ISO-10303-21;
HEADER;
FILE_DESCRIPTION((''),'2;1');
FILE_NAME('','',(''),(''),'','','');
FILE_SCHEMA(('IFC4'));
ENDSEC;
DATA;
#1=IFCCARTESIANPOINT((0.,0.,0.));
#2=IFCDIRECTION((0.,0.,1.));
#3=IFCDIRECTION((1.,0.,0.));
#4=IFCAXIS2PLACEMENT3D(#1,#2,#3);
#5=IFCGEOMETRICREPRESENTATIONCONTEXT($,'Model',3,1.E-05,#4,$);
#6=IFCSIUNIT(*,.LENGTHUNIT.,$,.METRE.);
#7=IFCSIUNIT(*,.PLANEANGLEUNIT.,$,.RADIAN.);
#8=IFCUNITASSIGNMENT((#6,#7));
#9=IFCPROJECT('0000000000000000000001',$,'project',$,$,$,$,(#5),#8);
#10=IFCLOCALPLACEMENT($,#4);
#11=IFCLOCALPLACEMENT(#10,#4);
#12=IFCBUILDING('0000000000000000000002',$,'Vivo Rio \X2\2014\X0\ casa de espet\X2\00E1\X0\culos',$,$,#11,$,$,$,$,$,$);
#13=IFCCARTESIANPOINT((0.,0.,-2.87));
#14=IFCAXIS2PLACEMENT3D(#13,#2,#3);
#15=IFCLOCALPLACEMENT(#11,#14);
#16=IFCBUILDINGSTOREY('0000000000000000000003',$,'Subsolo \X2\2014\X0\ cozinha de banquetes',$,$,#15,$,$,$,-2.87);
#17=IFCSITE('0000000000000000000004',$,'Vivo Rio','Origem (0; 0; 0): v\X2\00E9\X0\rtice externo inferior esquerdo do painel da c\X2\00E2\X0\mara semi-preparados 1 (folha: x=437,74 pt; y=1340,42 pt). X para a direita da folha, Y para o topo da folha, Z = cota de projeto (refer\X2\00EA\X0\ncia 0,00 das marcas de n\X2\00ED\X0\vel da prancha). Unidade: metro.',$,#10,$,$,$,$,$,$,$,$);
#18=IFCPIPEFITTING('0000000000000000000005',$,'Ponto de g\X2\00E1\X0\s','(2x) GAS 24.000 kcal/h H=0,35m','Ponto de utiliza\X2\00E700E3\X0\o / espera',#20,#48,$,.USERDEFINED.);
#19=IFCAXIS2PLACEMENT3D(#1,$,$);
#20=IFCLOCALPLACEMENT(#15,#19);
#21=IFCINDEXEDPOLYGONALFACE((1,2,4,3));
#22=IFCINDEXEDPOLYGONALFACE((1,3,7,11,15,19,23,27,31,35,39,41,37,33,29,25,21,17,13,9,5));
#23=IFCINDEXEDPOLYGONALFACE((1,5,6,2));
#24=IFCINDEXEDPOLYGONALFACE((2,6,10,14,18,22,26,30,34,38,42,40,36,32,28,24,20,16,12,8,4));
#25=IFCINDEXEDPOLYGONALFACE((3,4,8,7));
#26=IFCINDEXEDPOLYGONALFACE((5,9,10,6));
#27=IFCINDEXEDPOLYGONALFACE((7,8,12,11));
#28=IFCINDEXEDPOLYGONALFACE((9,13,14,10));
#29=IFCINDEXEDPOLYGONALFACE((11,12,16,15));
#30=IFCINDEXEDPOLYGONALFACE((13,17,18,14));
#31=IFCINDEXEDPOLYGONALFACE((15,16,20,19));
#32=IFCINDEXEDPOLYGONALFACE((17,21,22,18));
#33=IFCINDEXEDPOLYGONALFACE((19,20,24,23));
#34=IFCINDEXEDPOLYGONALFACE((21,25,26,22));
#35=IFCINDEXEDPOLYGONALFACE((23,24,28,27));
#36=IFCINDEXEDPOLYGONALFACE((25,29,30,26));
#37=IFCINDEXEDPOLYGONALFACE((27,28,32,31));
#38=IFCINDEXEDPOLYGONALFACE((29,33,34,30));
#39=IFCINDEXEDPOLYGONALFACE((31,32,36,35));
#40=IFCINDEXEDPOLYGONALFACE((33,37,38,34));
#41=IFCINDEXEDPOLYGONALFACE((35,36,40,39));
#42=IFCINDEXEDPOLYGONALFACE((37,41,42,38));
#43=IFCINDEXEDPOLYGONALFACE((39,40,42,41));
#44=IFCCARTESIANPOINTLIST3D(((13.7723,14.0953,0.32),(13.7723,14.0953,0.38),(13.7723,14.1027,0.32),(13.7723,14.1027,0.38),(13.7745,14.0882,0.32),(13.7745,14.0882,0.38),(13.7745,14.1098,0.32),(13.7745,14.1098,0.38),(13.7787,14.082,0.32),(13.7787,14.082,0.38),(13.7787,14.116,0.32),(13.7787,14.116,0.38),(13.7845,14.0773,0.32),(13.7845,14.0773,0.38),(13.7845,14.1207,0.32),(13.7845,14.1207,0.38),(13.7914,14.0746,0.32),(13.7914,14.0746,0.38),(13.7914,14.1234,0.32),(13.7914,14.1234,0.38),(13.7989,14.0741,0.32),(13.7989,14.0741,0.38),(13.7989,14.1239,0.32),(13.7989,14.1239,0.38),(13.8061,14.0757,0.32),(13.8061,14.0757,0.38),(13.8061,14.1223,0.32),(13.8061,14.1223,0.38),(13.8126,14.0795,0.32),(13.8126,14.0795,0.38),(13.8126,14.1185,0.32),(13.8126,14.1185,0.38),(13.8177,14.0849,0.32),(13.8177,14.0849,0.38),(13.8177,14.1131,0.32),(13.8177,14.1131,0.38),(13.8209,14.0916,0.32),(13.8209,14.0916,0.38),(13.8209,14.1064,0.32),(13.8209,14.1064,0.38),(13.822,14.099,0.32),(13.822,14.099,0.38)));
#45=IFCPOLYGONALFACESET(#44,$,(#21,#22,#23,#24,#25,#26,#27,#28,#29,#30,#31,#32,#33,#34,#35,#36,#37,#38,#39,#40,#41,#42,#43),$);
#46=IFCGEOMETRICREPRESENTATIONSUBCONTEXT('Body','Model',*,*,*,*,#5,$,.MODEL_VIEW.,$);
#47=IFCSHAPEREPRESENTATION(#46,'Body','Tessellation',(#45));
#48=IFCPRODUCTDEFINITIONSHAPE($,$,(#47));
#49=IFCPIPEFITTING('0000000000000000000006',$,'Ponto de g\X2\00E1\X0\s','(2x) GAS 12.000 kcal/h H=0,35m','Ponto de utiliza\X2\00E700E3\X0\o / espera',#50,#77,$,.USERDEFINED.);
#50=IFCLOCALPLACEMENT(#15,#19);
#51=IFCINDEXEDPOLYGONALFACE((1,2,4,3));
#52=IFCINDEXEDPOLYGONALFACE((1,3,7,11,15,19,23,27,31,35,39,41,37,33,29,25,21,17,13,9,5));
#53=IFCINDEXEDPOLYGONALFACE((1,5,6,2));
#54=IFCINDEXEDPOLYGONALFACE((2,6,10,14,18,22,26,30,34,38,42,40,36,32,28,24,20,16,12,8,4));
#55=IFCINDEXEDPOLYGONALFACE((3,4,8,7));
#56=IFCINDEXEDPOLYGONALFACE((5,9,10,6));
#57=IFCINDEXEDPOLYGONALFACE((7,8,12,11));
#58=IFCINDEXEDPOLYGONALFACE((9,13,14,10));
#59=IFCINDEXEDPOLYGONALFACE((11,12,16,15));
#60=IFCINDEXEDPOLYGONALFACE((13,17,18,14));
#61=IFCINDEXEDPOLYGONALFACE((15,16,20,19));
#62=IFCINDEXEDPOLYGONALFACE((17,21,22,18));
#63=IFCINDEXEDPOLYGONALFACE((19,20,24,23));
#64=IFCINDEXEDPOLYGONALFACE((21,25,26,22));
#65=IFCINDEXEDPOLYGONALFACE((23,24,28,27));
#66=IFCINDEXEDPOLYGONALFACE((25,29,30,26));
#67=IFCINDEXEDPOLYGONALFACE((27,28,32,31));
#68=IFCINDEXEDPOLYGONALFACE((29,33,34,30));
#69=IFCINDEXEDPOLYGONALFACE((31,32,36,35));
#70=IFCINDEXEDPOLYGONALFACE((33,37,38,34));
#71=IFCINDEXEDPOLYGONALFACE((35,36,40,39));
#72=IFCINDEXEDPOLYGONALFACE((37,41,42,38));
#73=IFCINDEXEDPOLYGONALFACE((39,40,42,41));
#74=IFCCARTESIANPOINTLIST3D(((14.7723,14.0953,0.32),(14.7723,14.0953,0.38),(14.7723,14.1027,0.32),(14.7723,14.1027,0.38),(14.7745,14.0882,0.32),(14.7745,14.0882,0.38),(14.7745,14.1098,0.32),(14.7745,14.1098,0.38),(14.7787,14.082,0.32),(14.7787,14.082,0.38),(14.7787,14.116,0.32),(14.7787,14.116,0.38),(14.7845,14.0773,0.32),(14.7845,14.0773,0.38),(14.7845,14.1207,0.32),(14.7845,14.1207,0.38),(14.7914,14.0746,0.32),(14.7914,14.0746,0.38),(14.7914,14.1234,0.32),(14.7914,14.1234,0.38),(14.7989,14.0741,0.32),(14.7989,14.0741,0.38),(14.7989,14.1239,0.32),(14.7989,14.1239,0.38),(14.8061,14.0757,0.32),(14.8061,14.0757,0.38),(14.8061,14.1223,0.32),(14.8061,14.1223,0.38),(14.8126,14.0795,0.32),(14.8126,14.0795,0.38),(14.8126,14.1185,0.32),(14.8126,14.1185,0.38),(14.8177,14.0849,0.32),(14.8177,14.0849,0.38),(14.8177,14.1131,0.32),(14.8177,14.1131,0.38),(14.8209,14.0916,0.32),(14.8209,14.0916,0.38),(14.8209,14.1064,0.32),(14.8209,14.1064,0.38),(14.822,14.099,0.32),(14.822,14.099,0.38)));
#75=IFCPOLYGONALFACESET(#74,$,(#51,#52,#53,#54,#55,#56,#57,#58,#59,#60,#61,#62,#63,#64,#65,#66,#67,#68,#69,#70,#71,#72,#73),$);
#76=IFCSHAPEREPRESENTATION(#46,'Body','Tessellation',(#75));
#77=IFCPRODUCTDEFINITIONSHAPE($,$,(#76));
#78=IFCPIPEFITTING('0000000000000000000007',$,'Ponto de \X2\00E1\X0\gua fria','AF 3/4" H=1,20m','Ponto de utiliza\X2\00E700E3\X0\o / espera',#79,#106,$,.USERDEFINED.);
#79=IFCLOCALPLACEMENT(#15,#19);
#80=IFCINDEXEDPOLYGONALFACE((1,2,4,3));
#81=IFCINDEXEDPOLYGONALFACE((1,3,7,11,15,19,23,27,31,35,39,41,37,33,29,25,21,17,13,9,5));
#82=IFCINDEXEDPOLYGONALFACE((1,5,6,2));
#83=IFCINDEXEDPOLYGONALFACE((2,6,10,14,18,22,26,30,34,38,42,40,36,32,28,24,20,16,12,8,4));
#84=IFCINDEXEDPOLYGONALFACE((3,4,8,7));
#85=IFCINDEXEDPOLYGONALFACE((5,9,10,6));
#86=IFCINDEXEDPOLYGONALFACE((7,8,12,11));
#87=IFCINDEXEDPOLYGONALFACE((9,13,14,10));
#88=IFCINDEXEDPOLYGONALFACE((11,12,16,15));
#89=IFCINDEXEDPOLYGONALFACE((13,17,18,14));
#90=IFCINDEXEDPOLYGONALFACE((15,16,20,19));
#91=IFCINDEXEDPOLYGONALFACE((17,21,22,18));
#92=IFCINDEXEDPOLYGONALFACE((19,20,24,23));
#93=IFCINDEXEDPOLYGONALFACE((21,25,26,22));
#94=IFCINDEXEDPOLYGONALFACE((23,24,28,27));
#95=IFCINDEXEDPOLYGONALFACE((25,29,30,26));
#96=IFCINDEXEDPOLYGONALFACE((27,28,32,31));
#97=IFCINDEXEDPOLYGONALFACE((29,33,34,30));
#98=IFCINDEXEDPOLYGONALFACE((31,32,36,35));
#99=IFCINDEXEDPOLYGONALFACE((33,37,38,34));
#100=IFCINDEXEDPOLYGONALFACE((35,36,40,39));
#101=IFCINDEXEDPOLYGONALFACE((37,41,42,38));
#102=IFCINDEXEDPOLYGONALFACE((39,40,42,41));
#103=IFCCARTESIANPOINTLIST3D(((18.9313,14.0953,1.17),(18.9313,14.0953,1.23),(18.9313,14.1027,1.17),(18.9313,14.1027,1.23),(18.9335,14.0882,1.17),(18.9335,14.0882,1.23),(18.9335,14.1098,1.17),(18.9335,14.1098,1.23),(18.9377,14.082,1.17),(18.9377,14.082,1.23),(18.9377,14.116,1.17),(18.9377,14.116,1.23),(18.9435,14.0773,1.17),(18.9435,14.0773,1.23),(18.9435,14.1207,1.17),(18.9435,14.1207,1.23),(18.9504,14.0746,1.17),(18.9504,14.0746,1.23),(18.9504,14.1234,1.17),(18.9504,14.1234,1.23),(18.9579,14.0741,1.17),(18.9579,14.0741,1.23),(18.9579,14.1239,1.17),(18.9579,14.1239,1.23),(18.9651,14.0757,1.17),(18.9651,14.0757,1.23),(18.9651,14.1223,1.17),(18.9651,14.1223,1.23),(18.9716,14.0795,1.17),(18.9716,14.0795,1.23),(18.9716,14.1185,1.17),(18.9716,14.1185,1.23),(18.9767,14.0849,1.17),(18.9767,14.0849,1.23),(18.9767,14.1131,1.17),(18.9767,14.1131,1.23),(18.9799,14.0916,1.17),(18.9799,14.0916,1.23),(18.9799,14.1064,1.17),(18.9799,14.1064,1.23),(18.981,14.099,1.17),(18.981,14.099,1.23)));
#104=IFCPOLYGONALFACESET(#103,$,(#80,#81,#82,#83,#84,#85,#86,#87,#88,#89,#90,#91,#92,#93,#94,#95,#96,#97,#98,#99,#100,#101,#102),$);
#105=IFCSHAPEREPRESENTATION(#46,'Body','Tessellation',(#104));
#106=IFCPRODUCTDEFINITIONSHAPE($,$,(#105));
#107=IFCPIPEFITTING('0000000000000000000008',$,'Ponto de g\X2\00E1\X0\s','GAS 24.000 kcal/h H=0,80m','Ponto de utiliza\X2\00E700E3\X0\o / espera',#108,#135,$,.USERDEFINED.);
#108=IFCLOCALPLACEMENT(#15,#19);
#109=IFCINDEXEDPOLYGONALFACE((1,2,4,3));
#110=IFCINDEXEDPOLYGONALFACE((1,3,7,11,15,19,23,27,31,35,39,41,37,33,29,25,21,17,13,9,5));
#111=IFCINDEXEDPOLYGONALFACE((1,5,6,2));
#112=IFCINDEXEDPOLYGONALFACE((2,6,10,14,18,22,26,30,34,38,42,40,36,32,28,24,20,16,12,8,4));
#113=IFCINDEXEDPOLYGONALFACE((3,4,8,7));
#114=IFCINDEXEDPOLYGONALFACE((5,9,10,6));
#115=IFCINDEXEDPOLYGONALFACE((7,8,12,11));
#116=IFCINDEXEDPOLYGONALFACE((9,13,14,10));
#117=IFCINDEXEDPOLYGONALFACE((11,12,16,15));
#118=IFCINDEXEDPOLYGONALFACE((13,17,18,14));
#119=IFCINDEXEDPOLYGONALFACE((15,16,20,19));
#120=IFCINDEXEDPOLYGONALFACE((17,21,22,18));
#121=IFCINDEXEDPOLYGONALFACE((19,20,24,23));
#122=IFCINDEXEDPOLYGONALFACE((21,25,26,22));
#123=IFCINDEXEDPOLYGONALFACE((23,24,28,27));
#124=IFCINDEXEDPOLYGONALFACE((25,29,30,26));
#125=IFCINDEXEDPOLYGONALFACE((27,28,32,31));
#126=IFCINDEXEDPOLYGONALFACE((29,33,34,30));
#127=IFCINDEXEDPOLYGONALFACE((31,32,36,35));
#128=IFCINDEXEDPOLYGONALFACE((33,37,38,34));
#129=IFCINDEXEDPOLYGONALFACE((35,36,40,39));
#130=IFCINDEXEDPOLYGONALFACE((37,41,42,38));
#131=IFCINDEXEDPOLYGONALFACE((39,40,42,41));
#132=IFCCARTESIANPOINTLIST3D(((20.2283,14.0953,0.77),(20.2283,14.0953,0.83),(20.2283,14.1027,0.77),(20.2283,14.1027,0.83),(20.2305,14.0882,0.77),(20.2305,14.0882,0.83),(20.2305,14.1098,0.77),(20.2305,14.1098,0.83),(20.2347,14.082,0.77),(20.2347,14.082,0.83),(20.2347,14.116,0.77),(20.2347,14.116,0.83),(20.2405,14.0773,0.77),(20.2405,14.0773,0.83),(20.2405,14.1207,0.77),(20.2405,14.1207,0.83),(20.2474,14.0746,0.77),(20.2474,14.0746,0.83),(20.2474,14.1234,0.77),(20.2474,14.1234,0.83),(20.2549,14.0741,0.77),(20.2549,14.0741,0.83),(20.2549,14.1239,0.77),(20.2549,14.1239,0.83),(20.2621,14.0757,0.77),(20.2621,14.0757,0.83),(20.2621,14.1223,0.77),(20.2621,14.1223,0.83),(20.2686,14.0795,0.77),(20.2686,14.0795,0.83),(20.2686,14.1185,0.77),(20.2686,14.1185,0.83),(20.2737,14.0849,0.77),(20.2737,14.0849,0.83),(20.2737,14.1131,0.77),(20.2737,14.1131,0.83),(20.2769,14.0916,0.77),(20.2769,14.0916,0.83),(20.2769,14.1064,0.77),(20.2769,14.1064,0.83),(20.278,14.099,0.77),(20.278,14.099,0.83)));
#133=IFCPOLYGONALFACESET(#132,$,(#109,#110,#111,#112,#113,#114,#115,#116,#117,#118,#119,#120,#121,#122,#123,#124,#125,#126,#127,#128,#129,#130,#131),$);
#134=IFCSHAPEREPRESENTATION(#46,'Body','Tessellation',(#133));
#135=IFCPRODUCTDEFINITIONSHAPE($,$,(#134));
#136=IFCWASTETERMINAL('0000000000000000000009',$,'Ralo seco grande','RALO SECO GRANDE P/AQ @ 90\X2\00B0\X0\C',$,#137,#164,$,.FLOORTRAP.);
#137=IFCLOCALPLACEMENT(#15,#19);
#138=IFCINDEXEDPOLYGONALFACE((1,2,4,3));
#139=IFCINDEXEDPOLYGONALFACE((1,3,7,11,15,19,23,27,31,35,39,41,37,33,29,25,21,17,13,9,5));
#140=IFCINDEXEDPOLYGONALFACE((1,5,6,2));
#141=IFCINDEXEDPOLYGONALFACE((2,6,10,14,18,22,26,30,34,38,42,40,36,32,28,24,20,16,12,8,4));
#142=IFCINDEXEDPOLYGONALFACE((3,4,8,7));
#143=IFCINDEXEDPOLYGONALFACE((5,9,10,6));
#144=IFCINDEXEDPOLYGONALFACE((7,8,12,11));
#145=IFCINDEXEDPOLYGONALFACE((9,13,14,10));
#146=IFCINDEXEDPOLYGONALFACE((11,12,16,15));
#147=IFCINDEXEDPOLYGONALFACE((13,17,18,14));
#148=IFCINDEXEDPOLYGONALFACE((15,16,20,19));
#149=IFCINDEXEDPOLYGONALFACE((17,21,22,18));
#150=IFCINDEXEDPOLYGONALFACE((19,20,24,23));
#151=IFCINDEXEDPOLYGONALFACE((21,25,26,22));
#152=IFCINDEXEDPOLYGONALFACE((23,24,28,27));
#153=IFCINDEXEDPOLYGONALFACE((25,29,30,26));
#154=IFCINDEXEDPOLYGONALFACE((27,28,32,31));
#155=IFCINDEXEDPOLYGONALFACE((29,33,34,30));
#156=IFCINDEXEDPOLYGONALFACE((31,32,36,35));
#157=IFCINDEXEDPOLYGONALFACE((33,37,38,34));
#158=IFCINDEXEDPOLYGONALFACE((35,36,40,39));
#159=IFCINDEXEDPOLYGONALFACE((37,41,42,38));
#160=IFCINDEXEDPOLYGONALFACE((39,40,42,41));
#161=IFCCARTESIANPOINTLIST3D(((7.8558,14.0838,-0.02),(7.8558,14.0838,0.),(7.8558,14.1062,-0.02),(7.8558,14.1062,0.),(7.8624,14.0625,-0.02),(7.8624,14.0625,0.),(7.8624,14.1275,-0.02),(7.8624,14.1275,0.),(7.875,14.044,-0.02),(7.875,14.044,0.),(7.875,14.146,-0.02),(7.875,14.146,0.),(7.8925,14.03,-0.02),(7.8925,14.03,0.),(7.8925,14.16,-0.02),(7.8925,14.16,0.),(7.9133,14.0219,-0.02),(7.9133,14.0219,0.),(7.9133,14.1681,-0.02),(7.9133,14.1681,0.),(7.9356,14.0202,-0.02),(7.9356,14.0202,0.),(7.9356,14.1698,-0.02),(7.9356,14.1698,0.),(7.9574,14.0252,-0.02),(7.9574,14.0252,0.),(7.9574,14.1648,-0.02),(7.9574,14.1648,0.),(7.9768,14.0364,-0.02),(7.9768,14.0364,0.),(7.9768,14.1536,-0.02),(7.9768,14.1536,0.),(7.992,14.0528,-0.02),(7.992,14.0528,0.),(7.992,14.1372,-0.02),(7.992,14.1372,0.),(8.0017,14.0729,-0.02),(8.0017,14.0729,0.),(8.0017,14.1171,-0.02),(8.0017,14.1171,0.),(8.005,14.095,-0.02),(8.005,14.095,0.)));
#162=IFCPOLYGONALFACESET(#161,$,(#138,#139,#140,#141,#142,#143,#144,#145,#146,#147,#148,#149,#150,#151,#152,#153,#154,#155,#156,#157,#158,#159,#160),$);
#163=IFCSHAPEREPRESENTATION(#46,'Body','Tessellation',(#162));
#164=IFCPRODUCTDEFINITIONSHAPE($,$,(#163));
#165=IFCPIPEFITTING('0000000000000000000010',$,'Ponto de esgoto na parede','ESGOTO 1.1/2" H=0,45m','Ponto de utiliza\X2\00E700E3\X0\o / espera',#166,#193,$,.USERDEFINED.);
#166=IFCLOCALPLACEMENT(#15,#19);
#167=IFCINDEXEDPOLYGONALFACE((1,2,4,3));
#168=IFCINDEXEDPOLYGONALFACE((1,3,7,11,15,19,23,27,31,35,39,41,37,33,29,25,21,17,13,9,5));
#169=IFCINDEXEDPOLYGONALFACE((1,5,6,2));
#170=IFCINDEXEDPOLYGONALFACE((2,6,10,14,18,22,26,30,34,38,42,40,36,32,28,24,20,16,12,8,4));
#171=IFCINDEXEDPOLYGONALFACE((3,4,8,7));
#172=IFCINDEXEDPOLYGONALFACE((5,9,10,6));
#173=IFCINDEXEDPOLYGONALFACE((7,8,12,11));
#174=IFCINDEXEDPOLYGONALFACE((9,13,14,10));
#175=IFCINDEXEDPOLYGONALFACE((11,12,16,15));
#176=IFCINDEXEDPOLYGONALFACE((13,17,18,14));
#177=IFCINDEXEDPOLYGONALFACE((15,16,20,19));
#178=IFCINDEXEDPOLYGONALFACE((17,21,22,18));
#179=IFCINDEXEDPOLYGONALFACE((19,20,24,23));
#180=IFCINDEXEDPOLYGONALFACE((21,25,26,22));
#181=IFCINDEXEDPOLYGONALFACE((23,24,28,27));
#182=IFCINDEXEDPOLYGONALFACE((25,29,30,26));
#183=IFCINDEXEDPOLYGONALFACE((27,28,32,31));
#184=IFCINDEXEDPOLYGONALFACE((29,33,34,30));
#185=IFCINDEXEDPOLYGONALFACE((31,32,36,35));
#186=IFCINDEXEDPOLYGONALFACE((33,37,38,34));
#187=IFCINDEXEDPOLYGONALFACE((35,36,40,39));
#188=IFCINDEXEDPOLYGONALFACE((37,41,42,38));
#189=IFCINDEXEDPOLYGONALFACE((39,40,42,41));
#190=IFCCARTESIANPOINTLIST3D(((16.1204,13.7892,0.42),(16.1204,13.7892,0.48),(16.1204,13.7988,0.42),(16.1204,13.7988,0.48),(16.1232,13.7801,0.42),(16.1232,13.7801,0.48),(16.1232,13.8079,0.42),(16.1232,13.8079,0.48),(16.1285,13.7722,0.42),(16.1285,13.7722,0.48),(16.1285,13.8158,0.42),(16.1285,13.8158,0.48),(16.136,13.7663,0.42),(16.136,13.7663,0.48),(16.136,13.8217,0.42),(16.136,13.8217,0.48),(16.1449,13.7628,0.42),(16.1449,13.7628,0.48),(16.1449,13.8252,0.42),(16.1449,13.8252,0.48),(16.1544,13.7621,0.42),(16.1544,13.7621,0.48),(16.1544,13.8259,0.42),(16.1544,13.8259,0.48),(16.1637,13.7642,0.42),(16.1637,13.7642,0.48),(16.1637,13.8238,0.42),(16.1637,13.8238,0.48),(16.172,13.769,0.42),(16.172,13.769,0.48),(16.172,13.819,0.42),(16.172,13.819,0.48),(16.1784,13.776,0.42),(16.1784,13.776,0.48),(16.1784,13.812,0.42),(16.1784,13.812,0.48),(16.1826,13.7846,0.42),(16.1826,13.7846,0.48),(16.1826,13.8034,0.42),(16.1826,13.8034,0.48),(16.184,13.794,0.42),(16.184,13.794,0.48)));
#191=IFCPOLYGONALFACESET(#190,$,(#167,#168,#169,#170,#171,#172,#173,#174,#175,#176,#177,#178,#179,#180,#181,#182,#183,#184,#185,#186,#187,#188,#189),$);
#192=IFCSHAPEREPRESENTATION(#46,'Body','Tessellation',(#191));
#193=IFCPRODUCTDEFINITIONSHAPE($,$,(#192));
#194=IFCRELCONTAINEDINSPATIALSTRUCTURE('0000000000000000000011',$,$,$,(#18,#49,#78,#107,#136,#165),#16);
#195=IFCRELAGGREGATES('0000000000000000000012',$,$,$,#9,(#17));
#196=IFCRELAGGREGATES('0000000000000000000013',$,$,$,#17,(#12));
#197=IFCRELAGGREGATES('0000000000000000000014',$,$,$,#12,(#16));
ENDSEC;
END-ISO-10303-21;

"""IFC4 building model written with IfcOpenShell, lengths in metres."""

from ifc_helpers import new_model, si_unit, frame, origin_with_axes, origin_2d, place, context, subcontext, project, spatial, circle, extrude, element, save


model = new_model("IFC4")

# Units and contexts
model_context = context("Model", 3, precision=1e-05, world=origin_with_axes())
body_context = subcontext(model_context, "Body", "Model", "MODEL_VIEW")
ifc_project = project(units=[si_unit("LENGTHUNIT", "METRE"), si_unit("PLANEANGLEUNIT", "RADIAN")], contexts=[model_context])

# Site, building, storey
site_placement = place(None, origin_with_axes())
site = spatial("IfcSite", under=ifc_project, at=site_placement, Name="Vivo Rio", Description="Origem (0; 0; 0): vértice externo inferior esquerdo do painel da câmara semi-preparados 1 (folha: x=437,74 pt; y=1340,42 pt). X para a direita da folha, Y para o topo da folha, Z = cota de projeto (referência 0,00 das marcas de nível da prancha). Unidade: metro.")
building_placement = place(site_placement, origin_with_axes())
building = spatial("IfcBuilding", under=site, at=building_placement, Name="Vivo Rio — casa de espetáculos")
storey_placement = place(building_placement, frame((0.0, 0.0, -2.87), z_axis=(0.0, 0.0, 1.0), x_axis=(1.0, 0.0, 0.0)))
storey = spatial("IfcBuildingStorey", under=building, at=storey_placement, Name="Subsolo — cozinha de banquetes", Elevation=-2.87)

# Pipe fittings
pipe_fitting_1_placement = place(storey_placement, origin_with_axes())
element("IfcPipeFitting", 1, at=pipe_fitting_1_placement, inside=storey, Name="Ponto de gás", Description="(2x) GAS 24.000 kcal/h H=0,35m", ObjectType="Ponto de utilização / espera", PredefinedType="USERDEFINED", context=body_context, shape_type="SweptSolid", body=[
    extrude(circle(Radius=0.025, at=origin_2d()), frame((13.797, 14.099, 0.32), z_axis=(0.0, 0.0, 1.0), x_axis=(1.0, 0.0, 0.0)), (0.0, 0.0, 1.0), 0.06),
])
pipe_fitting_2_placement = place(storey_placement, origin_with_axes())
element("IfcPipeFitting", 2, at=pipe_fitting_2_placement, inside=storey, Name="Ponto de gás", Description="(2x) GAS 12.000 kcal/h H=0,35m", ObjectType="Ponto de utilização / espera", PredefinedType="USERDEFINED", context=body_context, shape_type="SweptSolid", body=[
    extrude(circle(Radius=0.025, at=origin_2d()), frame((14.797, 14.099, 0.32), z_axis=(0.0, 0.0, 1.0), x_axis=(1.0, 0.0, 0.0)), (0.0, 0.0, 1.0), 0.06),
])
pipe_fitting_3_placement = place(storey_placement, origin_with_axes())
element("IfcPipeFitting", 3, at=pipe_fitting_3_placement, inside=storey, Name="Ponto de água fria", Description="AF 3/4\" H=1,20m", ObjectType="Ponto de utilização / espera", PredefinedType="USERDEFINED", context=body_context, shape_type="SweptSolid", body=[
    extrude(circle(Radius=0.025, at=origin_2d()), frame((18.956, 14.099, 1.17), z_axis=(0.0, 0.0, 1.0), x_axis=(1.0, 0.0, 0.0)), (0.0, 0.0, 1.0), 0.06),
])
pipe_fitting_4_placement = place(storey_placement, origin_with_axes())
element("IfcPipeFitting", 4, at=pipe_fitting_4_placement, inside=storey, Name="Ponto de gás", Description="GAS 24.000 kcal/h H=0,80m", ObjectType="Ponto de utilização / espera", PredefinedType="USERDEFINED", context=body_context, shape_type="SweptSolid", body=[
    extrude(circle(Radius=0.025, at=origin_2d()), frame((20.253, 14.099, 0.77), z_axis=(0.0, 0.0, 1.0), x_axis=(1.0, 0.0, 0.0)), (0.0, 0.0, 1.0), 0.06),
])

# Waste terminal
waste_terminal_1_placement = place(storey_placement, origin_with_axes())
element("IfcWasteTerminal", 5, at=waste_terminal_1_placement, inside=storey, Name="Ralo seco grande", Description="RALO SECO GRANDE P/AQ @ 90°C", PredefinedType="FLOORTRAP", context=body_context, shape_type="SweptSolid", body=[
    extrude(circle(Radius=0.075, at=origin_2d()), frame((7.93, 14.095, -0.02), z_axis=(0.0, 0.0, 1.0), x_axis=(1.0, 0.0, 0.0)), (0.0, 0.0, 1.0), 0.02),
])

# Pipe fitting
pipe_fitting_5_placement = place(storey_placement, origin_with_axes())
element("IfcPipeFitting", 6, at=pipe_fitting_5_placement, inside=storey, Name="Ponto de esgoto na parede", Description="ESGOTO 1.1/2\" H=0,45m", ObjectType="Ponto de utilização / espera", PredefinedType="USERDEFINED", context=body_context, shape_type="SweptSolid", body=[
    extrude(circle(Radius=0.032, at=origin_2d()), frame((16.152, 13.794, 0.42), z_axis=(0.0, 0.0, 1.0), x_axis=(1.0, 0.0, 0.0)), (0.0, 0.0, 1.0), 0.06),
])

save(model, "model.ifc")
